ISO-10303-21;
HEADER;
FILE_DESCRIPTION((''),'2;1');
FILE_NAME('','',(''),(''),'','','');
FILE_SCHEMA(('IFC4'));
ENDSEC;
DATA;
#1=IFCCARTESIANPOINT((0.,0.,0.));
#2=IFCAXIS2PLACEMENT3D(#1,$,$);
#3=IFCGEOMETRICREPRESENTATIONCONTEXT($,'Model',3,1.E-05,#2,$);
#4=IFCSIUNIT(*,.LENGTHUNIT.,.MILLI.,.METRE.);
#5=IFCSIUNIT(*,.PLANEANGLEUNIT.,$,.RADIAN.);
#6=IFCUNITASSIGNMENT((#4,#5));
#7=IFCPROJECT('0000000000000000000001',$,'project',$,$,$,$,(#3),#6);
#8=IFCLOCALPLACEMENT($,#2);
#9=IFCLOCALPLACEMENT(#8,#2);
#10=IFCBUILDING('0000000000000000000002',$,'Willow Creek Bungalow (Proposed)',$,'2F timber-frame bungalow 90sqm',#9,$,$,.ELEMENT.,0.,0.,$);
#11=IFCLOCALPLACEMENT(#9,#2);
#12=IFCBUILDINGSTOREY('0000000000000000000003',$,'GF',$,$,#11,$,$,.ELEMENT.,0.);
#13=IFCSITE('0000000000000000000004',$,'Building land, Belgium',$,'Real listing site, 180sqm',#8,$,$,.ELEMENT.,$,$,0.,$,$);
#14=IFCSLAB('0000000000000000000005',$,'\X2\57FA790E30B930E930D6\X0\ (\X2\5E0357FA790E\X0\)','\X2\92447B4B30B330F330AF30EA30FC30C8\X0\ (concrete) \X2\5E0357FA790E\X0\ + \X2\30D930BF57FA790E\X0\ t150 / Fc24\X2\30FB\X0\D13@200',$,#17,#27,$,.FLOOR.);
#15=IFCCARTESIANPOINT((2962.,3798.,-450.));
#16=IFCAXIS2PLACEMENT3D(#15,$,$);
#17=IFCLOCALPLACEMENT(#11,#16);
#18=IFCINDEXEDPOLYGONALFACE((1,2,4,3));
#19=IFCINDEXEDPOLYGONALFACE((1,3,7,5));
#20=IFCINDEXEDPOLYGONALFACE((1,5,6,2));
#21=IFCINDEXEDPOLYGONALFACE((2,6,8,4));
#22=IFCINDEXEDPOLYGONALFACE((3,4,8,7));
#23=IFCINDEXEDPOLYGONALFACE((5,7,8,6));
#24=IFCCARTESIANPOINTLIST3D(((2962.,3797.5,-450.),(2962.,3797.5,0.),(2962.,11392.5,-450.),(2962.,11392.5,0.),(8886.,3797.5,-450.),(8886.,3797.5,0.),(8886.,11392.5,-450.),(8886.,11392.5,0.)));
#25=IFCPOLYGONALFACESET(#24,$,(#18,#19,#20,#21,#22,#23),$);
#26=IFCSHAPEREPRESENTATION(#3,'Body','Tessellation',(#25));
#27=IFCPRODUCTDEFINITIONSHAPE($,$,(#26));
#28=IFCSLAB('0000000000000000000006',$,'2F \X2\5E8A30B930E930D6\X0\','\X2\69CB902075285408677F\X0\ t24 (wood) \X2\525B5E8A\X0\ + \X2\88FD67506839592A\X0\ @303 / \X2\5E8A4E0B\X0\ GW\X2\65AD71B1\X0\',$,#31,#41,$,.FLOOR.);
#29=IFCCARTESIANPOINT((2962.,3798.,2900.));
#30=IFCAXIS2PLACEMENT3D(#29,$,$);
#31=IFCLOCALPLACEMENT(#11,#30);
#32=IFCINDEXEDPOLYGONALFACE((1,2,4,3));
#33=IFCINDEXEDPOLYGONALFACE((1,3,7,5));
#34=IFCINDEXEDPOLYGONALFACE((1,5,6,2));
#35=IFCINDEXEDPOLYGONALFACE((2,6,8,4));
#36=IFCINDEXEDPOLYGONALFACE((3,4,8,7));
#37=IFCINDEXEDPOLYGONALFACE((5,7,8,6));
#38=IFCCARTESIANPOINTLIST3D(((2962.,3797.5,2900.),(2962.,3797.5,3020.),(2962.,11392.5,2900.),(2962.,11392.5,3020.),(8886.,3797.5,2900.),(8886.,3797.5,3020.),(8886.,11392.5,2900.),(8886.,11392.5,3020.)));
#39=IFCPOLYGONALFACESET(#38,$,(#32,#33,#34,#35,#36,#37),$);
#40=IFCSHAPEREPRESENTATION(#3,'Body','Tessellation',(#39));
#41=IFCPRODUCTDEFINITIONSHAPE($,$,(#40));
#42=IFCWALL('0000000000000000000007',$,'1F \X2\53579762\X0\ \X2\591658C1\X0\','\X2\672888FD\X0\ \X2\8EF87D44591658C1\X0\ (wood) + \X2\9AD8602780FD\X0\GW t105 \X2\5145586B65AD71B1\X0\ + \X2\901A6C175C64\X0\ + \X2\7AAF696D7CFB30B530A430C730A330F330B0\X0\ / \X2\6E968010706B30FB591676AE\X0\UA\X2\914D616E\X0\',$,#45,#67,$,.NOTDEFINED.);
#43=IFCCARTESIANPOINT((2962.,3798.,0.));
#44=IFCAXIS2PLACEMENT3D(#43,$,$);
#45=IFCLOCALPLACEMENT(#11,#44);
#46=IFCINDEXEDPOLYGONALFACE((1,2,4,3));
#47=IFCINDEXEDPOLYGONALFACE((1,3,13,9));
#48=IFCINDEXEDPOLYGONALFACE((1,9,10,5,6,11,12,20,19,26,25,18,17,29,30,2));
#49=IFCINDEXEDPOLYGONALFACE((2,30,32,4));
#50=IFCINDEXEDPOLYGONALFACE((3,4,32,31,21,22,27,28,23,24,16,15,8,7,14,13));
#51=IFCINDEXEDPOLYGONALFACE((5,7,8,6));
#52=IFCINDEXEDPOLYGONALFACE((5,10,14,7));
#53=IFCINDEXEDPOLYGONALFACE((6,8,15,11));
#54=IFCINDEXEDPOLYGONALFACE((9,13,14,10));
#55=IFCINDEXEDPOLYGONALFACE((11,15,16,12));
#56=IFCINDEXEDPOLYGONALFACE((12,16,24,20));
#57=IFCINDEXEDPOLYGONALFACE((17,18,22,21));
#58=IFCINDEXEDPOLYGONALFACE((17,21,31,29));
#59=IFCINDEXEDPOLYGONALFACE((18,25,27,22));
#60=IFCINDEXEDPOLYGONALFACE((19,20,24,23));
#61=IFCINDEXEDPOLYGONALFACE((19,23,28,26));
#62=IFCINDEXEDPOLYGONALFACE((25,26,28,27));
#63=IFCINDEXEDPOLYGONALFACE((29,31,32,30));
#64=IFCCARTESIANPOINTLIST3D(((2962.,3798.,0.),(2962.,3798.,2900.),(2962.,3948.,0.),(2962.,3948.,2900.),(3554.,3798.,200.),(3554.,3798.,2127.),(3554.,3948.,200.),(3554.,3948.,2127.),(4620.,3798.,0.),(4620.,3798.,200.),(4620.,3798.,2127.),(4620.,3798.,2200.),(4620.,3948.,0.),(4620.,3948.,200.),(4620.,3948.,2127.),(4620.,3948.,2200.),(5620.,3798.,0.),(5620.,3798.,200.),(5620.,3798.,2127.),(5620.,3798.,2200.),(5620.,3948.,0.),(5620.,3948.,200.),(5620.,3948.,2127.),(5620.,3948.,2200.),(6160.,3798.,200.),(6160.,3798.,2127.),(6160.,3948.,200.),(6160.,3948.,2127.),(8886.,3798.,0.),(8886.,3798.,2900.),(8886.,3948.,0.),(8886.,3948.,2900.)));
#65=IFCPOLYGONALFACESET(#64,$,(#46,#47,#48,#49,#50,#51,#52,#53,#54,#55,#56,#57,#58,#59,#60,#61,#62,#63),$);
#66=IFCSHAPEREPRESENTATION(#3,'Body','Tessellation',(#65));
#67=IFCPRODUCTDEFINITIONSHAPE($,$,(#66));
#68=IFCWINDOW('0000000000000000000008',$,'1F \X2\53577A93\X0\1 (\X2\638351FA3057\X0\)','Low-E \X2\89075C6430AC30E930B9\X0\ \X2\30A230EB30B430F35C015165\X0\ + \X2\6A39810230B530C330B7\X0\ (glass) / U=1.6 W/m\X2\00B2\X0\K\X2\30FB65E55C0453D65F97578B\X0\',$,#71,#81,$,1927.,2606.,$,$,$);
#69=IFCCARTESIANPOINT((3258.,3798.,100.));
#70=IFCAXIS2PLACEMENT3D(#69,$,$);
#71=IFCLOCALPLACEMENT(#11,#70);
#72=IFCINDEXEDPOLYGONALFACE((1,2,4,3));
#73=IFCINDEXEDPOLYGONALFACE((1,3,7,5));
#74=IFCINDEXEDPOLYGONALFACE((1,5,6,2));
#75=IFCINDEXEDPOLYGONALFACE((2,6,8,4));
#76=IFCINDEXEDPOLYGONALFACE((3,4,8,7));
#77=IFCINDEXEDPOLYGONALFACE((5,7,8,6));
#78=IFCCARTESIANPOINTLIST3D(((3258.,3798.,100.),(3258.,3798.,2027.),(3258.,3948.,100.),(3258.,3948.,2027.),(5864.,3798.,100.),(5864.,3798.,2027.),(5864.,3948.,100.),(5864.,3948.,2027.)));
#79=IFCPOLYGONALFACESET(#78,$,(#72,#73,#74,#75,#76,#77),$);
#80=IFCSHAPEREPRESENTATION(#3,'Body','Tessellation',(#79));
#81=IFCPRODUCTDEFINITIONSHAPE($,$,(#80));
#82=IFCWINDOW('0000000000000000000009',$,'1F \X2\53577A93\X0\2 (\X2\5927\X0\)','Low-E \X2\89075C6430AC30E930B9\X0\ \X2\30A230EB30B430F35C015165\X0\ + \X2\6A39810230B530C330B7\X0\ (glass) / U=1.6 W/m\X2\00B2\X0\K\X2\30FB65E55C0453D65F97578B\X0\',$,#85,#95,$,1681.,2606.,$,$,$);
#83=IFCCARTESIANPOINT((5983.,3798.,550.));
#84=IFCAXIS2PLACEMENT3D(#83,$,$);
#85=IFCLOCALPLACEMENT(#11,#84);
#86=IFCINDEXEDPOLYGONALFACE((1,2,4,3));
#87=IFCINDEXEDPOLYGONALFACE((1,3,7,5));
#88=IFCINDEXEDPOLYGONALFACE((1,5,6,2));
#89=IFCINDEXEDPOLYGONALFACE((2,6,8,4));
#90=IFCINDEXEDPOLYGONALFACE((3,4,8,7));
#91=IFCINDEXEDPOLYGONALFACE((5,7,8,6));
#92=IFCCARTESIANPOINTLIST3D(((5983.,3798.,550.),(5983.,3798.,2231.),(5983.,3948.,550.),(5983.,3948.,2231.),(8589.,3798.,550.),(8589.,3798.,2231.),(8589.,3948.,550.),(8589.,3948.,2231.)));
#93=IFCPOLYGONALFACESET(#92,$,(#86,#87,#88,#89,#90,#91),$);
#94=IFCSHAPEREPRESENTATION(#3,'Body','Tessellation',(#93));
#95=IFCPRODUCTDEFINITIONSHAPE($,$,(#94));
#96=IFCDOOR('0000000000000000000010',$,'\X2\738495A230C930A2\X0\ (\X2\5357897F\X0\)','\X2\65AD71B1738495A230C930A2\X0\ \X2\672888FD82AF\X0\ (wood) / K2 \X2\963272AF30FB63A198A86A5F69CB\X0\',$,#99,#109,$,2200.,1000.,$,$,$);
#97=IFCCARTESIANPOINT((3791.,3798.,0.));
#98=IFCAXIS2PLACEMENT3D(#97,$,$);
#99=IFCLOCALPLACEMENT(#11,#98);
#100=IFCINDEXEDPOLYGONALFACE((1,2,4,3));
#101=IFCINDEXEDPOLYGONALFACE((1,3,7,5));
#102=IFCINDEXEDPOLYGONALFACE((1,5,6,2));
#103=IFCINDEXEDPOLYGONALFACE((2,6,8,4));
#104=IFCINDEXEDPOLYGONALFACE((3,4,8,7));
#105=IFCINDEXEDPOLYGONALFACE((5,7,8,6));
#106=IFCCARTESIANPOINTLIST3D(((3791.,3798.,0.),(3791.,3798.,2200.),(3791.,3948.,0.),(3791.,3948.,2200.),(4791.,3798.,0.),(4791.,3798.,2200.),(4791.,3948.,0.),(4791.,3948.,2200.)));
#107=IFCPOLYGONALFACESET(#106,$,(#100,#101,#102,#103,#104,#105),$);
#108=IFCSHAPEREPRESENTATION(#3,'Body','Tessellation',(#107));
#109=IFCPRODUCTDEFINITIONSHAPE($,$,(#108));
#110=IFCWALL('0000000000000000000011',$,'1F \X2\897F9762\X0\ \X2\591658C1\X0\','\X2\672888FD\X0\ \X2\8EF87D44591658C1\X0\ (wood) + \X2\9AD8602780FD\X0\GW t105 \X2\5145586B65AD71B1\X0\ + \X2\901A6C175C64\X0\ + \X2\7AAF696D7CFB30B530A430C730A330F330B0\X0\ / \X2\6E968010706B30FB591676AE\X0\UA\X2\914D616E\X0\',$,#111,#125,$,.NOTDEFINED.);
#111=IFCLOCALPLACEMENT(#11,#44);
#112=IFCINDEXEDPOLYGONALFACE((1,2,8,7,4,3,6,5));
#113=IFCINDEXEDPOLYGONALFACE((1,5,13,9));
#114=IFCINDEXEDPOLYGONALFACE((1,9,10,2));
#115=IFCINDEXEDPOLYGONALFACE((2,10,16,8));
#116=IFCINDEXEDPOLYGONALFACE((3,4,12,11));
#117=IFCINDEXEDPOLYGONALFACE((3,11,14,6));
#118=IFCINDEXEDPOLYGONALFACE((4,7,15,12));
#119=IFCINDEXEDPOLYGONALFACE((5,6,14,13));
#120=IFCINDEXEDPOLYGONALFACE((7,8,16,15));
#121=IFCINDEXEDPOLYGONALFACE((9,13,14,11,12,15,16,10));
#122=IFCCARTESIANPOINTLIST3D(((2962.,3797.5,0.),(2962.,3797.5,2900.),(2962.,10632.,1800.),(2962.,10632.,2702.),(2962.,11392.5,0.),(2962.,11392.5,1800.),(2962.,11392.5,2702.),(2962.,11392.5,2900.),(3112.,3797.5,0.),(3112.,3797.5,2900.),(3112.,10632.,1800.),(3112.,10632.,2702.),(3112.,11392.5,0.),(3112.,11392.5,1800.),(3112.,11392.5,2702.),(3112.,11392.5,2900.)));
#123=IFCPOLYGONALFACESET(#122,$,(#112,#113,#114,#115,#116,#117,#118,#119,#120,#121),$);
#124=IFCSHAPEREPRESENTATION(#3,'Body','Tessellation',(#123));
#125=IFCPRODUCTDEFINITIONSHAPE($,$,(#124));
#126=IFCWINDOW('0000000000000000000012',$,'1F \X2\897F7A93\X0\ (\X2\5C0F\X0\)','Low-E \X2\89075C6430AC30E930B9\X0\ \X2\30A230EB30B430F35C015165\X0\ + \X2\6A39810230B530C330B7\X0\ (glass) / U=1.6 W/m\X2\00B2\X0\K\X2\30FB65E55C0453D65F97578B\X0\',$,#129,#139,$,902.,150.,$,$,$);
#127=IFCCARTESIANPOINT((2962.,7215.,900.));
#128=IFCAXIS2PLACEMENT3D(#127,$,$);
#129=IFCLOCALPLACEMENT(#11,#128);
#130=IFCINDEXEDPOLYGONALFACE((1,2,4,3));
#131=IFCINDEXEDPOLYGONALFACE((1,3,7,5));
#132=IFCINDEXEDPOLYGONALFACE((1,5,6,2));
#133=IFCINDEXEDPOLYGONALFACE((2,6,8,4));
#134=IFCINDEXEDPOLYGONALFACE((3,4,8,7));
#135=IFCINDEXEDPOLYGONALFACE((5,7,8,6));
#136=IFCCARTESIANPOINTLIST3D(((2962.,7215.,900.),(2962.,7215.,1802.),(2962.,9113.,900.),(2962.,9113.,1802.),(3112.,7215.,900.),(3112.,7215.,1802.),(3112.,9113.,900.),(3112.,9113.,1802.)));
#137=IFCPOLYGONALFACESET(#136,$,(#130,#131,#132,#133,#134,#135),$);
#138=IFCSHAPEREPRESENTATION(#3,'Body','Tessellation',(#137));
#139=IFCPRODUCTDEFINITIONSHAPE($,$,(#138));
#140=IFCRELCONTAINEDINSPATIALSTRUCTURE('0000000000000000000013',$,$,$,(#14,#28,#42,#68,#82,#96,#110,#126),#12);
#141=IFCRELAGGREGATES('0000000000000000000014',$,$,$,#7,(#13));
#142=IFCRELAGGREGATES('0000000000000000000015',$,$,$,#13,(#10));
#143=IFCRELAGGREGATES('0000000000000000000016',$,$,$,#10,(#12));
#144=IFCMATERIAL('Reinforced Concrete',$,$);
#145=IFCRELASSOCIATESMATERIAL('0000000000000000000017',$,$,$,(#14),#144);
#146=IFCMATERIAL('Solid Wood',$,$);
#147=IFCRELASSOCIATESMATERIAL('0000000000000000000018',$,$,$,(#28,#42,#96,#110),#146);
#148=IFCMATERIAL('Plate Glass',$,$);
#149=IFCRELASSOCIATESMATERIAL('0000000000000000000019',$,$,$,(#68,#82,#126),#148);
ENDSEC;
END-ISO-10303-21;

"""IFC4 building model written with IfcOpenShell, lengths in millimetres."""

from ifc_helpers import new_model, si_unit, frame, frame_2d, origin, place, context, project, spatial, rectangle, extrude, material, element, fill, save


model = new_model("IFC4")

# Units and contexts
model_context = context("Model", 3, precision=1e-05, world=origin())
ifc_project = project(units=[si_unit("LENGTHUNIT", "METRE", prefix="MILLI"), si_unit("PLANEANGLEUNIT", "RADIAN")], contexts=[model_context])

# Site, building, storey
site_placement = place(None, origin())
site = spatial("IfcSite", under=ifc_project, at=site_placement, Name="Building land, Belgium", ObjectType="Real listing site, 180sqm", CompositionType="ELEMENT", RefElevation=0.0)
building_placement = place(site_placement, origin())
building = spatial("IfcBuilding", under=site, at=building_placement, Name="Willow Creek Bungalow (Proposed)", ObjectType="2F timber-frame bungalow 90sqm", CompositionType="ELEMENT", ElevationOfRefHeight=0.0, ElevationOfTerrain=0.0)
storey_placement = place(building_placement, origin())
storey = spatial("IfcBuildingStorey", under=building, at=storey_placement, Name="GF", CompositionType="ELEMENT", Elevation=0.0)

# Slabs
ifc_material_1 = material(Name="Reinforced Concrete")
slab_1_placement = place(storey_placement, frame((2962.0, 3798.0, -450.0)))
element("IfcSlab", 1, at=slab_1_placement, inside=storey, material=ifc_material_1, Name="基礎スラブ (布基礎)", Description="鉄筋コンクリート (concrete) 布基礎 + ベタ基礎 t150 / Fc24・D13@200", PredefinedType="FLOOR", context=model_context, shape_type="SweptSolid", body=[
    extrude(rectangle(XDim=5924.0, YDim=7595.0, at=frame_2d((2962.0, 3797.0))), frame((2962.0, 3798.0, -450.0)), (0.0, 0.0, 1.0), 450.0),
])
ifc_material_2 = material(Name="Solid Wood")
slab_2_placement = place(storey_placement, frame((2962.0, 3798.0, 2900.0)))
element("IfcSlab", 2, at=slab_2_placement, inside=storey, material=ifc_material_2, Name="2F 床スラブ", Description="構造用合板 t24 (wood) 剛床 + 製材根太 @303 / 床下 GW断熱", PredefinedType="FLOOR", context=model_context, shape_type="SweptSolid", body=[
    extrude(rectangle(XDim=5924.0, YDim=7595.0, at=frame_2d((2962.0, 3797.0))), frame((2962.0, 3798.0, 2900.0)), (0.0, 0.0, 1.0), 120.0),
])

# Wall, openings, windows, door
wall_1_placement = place(storey_placement, frame((2962.0, 3798.0, 0.0)))
wall_1 = element("IfcWall", 3, at=wall_1_placement, inside=storey, material=ifc_material_2, Name="1F 南面 外壁", Description="木製 軸組外壁 (wood) + 高性能GW t105 充填断熱 + 通気層 + 窯業系サイディング / 準耐火・外皮UA配慮", PredefinedType="NOTDEFINED", context=model_context, shape_type="SweptSolid", body=[
    extrude(rectangle(XDim=5924.0, YDim=150.0, at=frame_2d((2962.0, 75.0))), frame((2962.0, 3798.0, 0.0)), (0.0, 0.0, 1.0), 2900.0),
])
opening_1_placement = place(storey_placement, frame((3258.0, 3798.0, 100.0)))
opening_1 = element("IfcOpeningElement", 4, at=opening_1_placement, cuts=wall_1, PredefinedType="NOTDEFINED", context=model_context, shape_type="SweptSolid", body=[
    extrude(rectangle(XDim=2606.0, YDim=150.0, at=frame_2d((1303.0, 75.0))), frame((3258.0, 3798.0, 100.0)), (0.0, 0.0, 1.0), 1927.0),
])
opening_2_placement = place(storey_placement, frame((5983.0, 3798.0, 550.0)))
opening_2 = element("IfcOpeningElement", 5, at=opening_2_placement, cuts=wall_1, PredefinedType="NOTDEFINED", context=model_context, shape_type="SweptSolid", body=[
    extrude(rectangle(XDim=2606.0, YDim=150.0, at=frame_2d((1303.0, 75.0))), frame((5983.0, 3798.0, 550.0)), (0.0, 0.0, 1.0), 1681.0),
])
opening_3_placement = place(storey_placement, frame((3791.0, 3798.0, 0.0)))
opening_3 = element("IfcOpeningElement", 6, at=opening_3_placement, cuts=wall_1, PredefinedType="NOTDEFINED", context=model_context, shape_type="SweptSolid", body=[
    extrude(rectangle(XDim=1000.0, YDim=150.0, at=frame_2d((500.0, 75.0))), frame((3791.0, 3798.0, 0.0)), (0.0, 0.0, 1.0), 2200.0),
])
ifc_material_3 = material(Name="Plate Glass")
window_1_placement = place(storey_placement, frame((3258.0, 3798.0, 100.0)))
window_1 = element("IfcWindow", 7, at=window_1_placement, inside=storey, material=ifc_material_3, Name="1F 南窓1 (掃出し)", Description="Low-E 複層ガラス アルゴン封入 + 樹脂サッシ (glass) / U=1.6 W/m²K・日射取得型", OverallHeight=1927.0, OverallWidth=2606.0, context=model_context, shape_type="SweptSolid", body=[
    extrude(rectangle(XDim=2606.0, YDim=150.0, at=frame_2d((1303.0, 75.0))), frame((3258.0, 3798.0, 100.0)), (0.0, 0.0, 1.0), 1927.0),
])
fill(opening_1, window_1)
window_2_placement = place(storey_placement, frame((5983.0, 3798.0, 550.0)))
window_2 = element("IfcWindow", 8, at=window_2_placement, inside=storey, material=ifc_material_3, Name="1F 南窓2 (大)", Description="Low-E 複層ガラス アルゴン封入 + 樹脂サッシ (glass) / U=1.6 W/m²K・日射取得型", OverallHeight=1681.0, OverallWidth=2606.0, context=model_context, shape_type="SweptSolid", body=[
    extrude(rectangle(XDim=2606.0, YDim=150.0, at=frame_2d((1303.0, 75.0))), frame((5983.0, 3798.0, 550.0)), (0.0, 0.0, 1.0), 1681.0),
])
fill(opening_2, window_2)
door_placement = place(storey_placement, frame((3791.0, 3798.0, 0.0)))
door = element("IfcDoor", 9, at=door_placement, inside=storey, material=ifc_material_2, Name="玄関ドア (南西)", Description="断熱玄関ドア 木製芯 (wood) / K2 防犯・採風機構", OverallHeight=2200.0, OverallWidth=1000.0, context=model_context, shape_type="SweptSolid", body=[
    extrude(rectangle(XDim=1000.0, YDim=150.0, at=frame_2d((500.0, 75.0))), frame((3791.0, 3798.0, 0.0)), (0.0, 0.0, 1.0), 2200.0),
])
fill(opening_3, door)

# Wall, opening, window
wall_2_placement = place(storey_placement, frame((2962.0, 3798.0, 0.0)))
wall_2 = element("IfcWall", 10, at=wall_2_placement, inside=storey, material=ifc_material_2, Name="1F 西面 外壁", Description="木製 軸組外壁 (wood) + 高性能GW t105 充填断熱 + 通気層 + 窯業系サイディング / 準耐火・外皮UA配慮", PredefinedType="NOTDEFINED", context=model_context, shape_type="SweptSolid", body=[
    extrude(rectangle(XDim=150.0, YDim=7595.0, at=frame_2d((75.0, 3797.0))), frame((2962.0, 3798.0, 0.0)), (0.0, 0.0, 1.0), 2900.0),
])
opening_4_placement = place(storey_placement, frame((2962.0, 7215.0, 900.0)))
opening_4 = element("IfcOpeningElement", 11, at=opening_4_placement, cuts=wall_2, PredefinedType="NOTDEFINED", context=model_context, shape_type="SweptSolid", body=[
    extrude(rectangle(XDim=150.0, YDim=1898.0, at=frame_2d((75.0, 949.0))), frame((2962.0, 7215.0, 900.0)), (0.0, 0.0, 1.0), 902.0),
])
window_3_placement = place(storey_placement, frame((2962.0, 7215.0, 900.0)))
window_3 = element("IfcWindow", 12, at=window_3_placement, inside=storey, material=ifc_material_3, Name="1F 西窓 (小)", Description="Low-E 複層ガラス アルゴン封入 + 樹脂サッシ (glass) / U=1.6 W/m²K・日射取得型", OverallHeight=902.0, OverallWidth=150.0, context=model_context, shape_type="SweptSolid", body=[
    extrude(rectangle(XDim=150.0, YDim=1898.0, at=frame_2d((75.0, 949.0))), frame((2962.0, 7215.0, 900.0)), (0.0, 0.0, 1.0), 902.0),
])
fill(opening_4, window_3)

save(model, "model.ifc")
